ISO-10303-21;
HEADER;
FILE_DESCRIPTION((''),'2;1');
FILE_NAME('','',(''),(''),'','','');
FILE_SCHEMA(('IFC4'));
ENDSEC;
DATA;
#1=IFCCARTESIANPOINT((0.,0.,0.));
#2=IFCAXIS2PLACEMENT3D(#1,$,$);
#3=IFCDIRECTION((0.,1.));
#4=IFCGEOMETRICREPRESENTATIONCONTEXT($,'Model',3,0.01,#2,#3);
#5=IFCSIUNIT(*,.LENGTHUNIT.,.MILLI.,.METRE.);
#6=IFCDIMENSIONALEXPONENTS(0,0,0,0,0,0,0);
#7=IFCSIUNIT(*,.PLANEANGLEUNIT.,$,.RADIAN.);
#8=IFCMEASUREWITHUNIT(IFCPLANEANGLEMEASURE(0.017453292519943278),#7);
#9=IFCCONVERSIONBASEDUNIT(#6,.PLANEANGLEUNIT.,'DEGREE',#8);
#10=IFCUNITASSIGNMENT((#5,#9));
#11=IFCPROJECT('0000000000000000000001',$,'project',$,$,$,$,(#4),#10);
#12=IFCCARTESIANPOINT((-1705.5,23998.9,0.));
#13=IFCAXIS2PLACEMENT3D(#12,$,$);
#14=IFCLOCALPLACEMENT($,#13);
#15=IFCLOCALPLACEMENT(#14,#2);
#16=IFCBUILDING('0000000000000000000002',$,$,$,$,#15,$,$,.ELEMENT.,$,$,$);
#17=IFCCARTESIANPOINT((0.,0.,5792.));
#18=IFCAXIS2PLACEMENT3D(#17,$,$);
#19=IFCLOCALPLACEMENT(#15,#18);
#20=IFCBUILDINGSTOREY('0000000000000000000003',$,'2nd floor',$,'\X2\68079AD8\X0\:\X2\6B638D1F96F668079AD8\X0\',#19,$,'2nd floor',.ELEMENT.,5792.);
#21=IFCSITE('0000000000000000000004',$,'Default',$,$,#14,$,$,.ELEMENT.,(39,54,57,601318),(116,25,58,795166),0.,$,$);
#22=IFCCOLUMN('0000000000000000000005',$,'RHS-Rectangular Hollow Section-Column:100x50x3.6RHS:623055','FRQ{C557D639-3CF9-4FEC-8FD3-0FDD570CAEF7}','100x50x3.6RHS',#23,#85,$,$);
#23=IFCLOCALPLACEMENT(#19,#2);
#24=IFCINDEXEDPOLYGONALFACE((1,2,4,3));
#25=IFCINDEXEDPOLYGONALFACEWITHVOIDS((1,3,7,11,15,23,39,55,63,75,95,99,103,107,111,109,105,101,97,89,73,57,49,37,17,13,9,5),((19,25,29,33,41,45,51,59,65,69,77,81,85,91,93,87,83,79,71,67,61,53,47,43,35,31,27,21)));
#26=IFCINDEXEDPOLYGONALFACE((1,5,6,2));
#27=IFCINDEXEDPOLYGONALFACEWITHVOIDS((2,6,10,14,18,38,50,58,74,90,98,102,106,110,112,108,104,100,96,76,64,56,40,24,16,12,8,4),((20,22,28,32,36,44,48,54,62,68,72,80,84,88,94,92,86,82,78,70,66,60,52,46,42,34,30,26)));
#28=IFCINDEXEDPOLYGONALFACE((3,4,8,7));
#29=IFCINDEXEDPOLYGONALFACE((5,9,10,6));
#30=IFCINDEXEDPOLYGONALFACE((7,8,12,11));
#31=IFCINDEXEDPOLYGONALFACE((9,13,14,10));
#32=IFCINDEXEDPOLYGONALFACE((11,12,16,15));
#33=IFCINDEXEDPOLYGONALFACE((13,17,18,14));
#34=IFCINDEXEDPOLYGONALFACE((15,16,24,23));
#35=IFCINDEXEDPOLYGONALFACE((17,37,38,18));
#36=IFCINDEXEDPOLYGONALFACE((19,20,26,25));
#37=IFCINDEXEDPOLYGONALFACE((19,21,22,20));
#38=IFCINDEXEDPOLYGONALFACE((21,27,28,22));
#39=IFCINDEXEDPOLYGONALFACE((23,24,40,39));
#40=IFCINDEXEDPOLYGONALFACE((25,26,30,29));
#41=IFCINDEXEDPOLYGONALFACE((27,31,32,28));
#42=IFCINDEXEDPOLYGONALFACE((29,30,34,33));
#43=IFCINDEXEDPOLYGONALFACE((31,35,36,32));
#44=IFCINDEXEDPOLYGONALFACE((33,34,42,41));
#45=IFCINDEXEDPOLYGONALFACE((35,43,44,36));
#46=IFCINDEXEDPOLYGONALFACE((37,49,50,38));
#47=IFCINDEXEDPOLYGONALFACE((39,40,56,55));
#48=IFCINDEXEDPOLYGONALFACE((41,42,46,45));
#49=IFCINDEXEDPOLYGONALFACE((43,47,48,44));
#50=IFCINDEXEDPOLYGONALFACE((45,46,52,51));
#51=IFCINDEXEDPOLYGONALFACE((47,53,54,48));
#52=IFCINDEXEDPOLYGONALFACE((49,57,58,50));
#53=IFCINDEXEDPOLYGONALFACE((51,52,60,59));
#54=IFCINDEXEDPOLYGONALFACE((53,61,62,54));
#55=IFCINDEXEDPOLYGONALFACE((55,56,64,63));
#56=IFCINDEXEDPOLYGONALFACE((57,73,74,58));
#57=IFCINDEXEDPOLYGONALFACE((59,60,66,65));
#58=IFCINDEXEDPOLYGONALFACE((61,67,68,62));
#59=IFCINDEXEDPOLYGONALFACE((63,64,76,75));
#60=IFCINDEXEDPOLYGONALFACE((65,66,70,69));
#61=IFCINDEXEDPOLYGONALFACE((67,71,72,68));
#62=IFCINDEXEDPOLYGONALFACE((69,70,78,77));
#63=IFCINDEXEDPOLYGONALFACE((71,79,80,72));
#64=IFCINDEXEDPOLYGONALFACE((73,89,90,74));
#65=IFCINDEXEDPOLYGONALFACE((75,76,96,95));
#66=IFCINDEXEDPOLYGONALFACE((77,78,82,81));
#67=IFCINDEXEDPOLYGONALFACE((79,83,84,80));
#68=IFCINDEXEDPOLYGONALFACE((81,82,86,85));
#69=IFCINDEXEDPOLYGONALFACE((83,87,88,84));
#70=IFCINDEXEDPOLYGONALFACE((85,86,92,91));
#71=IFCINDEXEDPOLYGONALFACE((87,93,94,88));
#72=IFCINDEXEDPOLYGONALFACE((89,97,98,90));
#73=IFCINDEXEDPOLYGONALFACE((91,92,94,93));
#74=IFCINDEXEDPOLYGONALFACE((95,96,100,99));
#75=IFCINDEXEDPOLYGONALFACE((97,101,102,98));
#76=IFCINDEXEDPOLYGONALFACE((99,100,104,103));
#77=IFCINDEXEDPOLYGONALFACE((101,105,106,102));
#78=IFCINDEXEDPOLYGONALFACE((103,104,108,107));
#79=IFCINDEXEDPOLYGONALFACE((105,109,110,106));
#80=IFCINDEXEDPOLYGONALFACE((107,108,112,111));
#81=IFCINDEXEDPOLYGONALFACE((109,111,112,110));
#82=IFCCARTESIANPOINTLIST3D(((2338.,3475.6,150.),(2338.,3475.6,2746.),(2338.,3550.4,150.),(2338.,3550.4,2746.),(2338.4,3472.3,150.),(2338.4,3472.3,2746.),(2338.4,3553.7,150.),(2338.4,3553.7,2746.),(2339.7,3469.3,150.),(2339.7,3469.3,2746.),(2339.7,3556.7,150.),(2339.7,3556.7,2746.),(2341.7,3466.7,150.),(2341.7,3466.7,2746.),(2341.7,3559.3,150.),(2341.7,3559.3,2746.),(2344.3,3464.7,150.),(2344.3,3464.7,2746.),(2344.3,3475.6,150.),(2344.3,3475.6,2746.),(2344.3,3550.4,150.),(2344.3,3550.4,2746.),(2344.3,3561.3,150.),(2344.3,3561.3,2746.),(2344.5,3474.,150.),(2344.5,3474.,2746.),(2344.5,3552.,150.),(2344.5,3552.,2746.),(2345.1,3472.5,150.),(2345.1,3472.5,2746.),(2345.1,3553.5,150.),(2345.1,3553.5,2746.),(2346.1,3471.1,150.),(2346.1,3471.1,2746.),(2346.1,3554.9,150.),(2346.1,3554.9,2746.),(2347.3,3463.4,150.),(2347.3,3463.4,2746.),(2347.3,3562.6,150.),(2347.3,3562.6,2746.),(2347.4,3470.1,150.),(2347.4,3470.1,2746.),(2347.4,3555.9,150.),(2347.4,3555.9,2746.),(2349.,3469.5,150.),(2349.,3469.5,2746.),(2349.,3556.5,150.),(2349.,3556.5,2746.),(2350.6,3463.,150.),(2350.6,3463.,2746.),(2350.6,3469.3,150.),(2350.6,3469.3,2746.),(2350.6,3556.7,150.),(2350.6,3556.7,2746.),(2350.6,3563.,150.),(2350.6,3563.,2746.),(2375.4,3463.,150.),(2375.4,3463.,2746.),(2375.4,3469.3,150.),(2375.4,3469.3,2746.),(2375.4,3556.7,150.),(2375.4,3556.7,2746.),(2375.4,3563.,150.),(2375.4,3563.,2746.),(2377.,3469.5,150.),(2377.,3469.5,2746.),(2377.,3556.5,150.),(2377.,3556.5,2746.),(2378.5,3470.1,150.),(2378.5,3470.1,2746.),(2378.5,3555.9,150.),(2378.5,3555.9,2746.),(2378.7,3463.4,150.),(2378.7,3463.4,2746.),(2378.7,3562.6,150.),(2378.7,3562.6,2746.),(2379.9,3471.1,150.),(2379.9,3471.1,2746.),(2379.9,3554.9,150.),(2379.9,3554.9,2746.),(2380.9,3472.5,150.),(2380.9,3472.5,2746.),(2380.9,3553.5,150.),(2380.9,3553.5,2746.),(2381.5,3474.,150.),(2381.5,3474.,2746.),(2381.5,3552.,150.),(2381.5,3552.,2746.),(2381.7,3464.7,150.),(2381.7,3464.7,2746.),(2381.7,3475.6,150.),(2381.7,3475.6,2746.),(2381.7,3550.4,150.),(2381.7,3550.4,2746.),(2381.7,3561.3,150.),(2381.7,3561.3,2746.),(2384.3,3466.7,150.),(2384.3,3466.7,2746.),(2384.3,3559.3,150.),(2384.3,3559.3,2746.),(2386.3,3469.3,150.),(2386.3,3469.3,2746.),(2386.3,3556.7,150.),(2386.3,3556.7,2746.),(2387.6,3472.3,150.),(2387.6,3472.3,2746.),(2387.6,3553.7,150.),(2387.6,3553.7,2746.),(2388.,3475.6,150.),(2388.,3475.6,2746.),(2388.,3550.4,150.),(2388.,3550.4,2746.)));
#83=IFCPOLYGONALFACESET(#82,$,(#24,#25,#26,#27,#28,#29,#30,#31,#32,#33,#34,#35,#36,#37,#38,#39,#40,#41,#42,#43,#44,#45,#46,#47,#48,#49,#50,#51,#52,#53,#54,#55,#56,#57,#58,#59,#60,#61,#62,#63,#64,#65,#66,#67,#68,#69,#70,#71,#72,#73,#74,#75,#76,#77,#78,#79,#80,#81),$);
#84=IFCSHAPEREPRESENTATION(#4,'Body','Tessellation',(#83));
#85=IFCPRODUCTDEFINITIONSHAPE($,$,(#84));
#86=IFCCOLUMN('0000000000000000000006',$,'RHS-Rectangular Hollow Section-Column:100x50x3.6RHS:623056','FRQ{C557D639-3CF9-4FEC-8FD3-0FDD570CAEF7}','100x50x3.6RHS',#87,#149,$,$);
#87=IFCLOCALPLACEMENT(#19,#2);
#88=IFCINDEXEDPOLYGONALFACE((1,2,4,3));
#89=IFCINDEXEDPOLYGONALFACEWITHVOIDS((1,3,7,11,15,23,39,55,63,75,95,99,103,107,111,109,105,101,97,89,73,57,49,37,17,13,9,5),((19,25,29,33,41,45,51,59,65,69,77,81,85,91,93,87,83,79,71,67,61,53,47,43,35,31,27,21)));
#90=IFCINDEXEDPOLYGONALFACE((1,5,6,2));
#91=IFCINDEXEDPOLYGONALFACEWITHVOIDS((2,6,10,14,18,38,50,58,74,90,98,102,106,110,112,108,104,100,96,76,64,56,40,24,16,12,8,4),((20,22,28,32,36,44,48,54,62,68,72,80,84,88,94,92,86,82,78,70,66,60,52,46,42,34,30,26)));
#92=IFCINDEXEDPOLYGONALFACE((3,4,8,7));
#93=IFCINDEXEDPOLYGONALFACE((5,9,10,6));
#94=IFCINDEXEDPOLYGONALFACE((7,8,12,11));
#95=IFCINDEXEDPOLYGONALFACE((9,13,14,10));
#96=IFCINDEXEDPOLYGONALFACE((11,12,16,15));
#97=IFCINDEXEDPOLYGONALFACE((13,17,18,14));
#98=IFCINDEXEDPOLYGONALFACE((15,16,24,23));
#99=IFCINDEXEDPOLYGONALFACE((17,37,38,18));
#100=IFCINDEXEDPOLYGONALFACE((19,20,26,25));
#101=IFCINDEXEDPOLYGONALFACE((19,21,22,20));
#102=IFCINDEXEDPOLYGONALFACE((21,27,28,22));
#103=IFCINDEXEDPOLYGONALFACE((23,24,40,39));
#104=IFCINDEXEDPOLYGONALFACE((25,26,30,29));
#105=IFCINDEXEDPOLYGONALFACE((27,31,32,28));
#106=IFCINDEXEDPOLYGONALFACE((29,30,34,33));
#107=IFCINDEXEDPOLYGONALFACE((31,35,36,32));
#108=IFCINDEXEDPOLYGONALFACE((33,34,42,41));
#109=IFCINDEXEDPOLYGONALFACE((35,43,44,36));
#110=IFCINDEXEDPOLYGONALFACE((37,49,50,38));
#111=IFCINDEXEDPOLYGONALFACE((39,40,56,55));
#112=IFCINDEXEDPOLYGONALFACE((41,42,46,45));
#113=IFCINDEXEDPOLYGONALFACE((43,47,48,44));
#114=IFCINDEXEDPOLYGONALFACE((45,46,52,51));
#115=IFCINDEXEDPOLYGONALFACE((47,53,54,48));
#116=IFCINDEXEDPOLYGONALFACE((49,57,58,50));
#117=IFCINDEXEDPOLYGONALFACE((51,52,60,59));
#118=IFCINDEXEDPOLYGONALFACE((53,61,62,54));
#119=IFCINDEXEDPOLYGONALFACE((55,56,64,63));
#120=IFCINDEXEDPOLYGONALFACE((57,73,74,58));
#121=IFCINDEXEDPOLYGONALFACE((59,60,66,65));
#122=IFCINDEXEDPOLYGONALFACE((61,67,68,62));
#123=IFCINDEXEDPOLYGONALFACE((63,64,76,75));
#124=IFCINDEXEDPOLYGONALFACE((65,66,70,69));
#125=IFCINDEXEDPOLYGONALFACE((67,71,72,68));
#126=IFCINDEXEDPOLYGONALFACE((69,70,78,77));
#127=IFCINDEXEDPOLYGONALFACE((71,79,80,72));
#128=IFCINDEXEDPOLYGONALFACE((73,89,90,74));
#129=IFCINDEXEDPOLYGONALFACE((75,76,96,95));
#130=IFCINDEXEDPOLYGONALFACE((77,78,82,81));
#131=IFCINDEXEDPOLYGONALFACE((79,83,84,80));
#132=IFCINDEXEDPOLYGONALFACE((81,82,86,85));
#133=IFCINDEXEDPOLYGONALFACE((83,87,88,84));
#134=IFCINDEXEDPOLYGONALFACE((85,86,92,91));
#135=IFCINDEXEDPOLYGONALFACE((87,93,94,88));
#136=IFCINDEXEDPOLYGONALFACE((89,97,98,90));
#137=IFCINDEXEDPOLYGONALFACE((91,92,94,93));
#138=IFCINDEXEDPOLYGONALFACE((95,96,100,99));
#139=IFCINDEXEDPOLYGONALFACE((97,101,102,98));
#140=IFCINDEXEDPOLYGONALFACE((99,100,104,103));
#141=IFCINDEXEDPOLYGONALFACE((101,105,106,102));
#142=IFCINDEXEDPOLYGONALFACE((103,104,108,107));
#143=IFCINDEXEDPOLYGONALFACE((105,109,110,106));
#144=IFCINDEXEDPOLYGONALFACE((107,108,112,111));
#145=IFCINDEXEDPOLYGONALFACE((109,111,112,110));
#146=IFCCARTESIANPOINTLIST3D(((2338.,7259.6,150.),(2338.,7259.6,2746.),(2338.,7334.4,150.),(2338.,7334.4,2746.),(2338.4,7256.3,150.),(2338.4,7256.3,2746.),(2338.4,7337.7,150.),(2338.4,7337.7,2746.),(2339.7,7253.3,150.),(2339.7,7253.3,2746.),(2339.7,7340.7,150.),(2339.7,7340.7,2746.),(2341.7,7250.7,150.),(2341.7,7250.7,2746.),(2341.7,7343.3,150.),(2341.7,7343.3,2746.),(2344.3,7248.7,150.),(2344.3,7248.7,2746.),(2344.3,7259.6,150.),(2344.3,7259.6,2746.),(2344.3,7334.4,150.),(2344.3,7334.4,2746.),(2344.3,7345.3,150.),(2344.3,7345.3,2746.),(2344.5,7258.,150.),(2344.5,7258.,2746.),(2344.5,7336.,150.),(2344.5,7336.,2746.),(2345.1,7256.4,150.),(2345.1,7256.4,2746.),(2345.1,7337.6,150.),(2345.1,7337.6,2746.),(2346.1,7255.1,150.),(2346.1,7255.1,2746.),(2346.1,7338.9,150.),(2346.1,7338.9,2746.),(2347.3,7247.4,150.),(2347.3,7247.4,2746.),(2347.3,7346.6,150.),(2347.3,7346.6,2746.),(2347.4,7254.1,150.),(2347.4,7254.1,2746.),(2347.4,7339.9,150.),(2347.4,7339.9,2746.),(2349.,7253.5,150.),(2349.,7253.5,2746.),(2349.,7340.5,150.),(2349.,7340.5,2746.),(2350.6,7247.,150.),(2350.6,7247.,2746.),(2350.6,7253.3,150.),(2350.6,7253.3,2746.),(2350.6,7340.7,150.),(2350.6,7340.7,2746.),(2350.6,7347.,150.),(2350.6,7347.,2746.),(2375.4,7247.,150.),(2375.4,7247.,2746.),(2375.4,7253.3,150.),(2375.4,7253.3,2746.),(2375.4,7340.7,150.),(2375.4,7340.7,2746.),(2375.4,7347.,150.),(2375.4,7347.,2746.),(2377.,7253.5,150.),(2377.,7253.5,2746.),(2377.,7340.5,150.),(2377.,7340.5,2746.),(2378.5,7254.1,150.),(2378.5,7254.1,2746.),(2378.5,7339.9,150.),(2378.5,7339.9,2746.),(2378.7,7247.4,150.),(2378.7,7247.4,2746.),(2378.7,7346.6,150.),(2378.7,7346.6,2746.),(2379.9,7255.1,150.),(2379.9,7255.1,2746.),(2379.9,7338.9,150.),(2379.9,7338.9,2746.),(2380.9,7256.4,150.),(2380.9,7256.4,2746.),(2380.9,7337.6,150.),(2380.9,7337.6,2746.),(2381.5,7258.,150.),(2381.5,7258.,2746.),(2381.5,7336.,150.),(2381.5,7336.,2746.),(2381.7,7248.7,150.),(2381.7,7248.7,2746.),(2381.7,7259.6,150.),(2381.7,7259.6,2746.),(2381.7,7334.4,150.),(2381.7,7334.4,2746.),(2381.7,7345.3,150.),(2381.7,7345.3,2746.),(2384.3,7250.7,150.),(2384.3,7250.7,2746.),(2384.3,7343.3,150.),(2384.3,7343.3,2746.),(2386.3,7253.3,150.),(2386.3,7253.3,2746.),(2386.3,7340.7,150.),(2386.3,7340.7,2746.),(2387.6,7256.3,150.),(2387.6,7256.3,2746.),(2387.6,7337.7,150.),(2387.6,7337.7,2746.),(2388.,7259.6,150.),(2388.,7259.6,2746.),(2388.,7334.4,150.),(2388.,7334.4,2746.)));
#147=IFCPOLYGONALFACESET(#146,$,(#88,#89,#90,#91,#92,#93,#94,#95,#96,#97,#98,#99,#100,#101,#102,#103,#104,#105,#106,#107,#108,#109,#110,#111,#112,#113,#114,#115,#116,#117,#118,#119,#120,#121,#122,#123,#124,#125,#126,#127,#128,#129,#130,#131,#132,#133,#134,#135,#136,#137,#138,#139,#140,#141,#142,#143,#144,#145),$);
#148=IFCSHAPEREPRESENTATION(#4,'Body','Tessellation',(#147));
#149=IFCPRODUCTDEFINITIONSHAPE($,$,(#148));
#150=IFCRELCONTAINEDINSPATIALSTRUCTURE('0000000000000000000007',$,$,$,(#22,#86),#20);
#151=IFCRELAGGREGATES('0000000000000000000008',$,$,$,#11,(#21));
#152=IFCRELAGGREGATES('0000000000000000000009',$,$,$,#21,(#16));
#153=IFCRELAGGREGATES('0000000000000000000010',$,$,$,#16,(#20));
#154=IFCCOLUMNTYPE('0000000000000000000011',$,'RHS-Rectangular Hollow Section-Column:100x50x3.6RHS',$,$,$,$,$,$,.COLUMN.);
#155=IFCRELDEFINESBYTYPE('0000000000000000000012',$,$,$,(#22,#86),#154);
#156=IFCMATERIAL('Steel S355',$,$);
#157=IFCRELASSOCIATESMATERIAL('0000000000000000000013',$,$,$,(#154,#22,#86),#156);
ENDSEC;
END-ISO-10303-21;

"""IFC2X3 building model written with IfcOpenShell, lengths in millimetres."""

from ifc_helpers import new_model, entity, si_unit, converted_unit, direction, frame, origin, origin_2d, place, context, project, spatial, hollow_rectangle, extrude, clip, halfspace, material, type_object, element, save


model = new_model("IFC2X3")

# Units and contexts
model_context = context("Model", 3, precision=0.01, world=origin(), true_north=direction((0.0, 1.0)))
ifc_project = project(units=[si_unit("LENGTHUNIT", "METRE", prefix="MILLI"), converted_unit("PLANEANGLEUNIT", "DEGREE", entity("IfcPlaneAngleMeasure", 0.017453292519943278), si_unit("PLANEANGLEUNIT", "RADIAN"), dimensions=[0, 0, 0, 0, 0, 0, 0])], contexts=[model_context])

# Site, building, storey
site_placement = place(None, frame((-1705.5, 23998.9, 0.0)))
site = spatial("IfcSite", under=ifc_project, at=site_placement, Name="Default", CompositionType="ELEMENT", RefLatitude=(39, 54, 57, 601318), RefLongitude=(116, 25, 58, 795166), RefElevation=0.0)
building_placement = place(site_placement, origin())
building = spatial("IfcBuilding", under=site, at=building_placement, CompositionType="ELEMENT")
storey_placement = place(building_placement, frame((0.0, 0.0, 5792.0)))
storey = spatial("IfcBuildingStorey", under=building, at=storey_placement, Name="2nd floor", ObjectType="标高:正负零标高", LongName="2nd floor", CompositionType="ELEMENT", Elevation=5792.0)

# Shared definitions
ifc_material_1 = material(Name="Steel S355")

# Columns
column_type_1 = type_object("IfcColumnType", Name="RHS-Rectangular Hollow Section-Column:100x50x3.6RHS", PredefinedType="COLUMN", material=ifc_material_1)
column_1_placement = place(storey_placement, frame((2363.0, 3513.0, 2746.0), z_axis=(0.0, 0.0, 1.0), x_axis=(-1.0, 0.0, 0.0)))
element("IfcColumn", 1, at=column_1_placement, inside=storey, type_object=column_type_1, material=ifc_material_1, Name="RHS-Rectangular Hollow Section-Column:100x50x3.6RHS:623055", Description="FRQ{C557D639-3CF9-4FEC-8FD3-0FDD570CAEF7}", ObjectType="100x50x3.6RHS", context=model_context, shape_type="Clipping", body=[
    clip(extrude(hollow_rectangle(XDim=50.0, YDim=100.0, WallThickness=6.3, InnerFilletRadius=6.3, OuterFilletRadius=12.6, at=origin_2d()), origin(), (0.0, 0.0, -1.0), 2651.9), halfspace(frame((2363.0, 3513.0, -2596.0), z_axis=(0.0, 0.0, 1.0), x_axis=(-1.0, 0.0, 0.0)), True)),
])
column_2_placement = place(storey_placement, frame((2363.0, 7297.0, 2746.0), z_axis=(0.0, 0.0, 1.0), x_axis=(-1.0, 0.0, 0.0)))
element("IfcColumn", 2, at=column_2_placement, inside=storey, type_object=column_type_1, material=ifc_material_1, Name="RHS-Rectangular Hollow Section-Column:100x50x3.6RHS:623056", Description="FRQ{C557D639-3CF9-4FEC-8FD3-0FDD570CAEF7}", ObjectType="100x50x3.6RHS", context=model_context, shape_type="Clipping", body=[
    clip(extrude(hollow_rectangle(XDim=50.0, YDim=100.0, WallThickness=6.3, InnerFilletRadius=6.3, OuterFilletRadius=12.6, at=origin_2d()), origin(), (0.0, 0.0, -1.0), 2651.9), halfspace(frame((2363.0, 7297.0, -2596.0), z_axis=(0.0, 0.0, 1.0), x_axis=(-1.0, 0.0, 0.0)), True)),
])

save(model, "model.ifc")
